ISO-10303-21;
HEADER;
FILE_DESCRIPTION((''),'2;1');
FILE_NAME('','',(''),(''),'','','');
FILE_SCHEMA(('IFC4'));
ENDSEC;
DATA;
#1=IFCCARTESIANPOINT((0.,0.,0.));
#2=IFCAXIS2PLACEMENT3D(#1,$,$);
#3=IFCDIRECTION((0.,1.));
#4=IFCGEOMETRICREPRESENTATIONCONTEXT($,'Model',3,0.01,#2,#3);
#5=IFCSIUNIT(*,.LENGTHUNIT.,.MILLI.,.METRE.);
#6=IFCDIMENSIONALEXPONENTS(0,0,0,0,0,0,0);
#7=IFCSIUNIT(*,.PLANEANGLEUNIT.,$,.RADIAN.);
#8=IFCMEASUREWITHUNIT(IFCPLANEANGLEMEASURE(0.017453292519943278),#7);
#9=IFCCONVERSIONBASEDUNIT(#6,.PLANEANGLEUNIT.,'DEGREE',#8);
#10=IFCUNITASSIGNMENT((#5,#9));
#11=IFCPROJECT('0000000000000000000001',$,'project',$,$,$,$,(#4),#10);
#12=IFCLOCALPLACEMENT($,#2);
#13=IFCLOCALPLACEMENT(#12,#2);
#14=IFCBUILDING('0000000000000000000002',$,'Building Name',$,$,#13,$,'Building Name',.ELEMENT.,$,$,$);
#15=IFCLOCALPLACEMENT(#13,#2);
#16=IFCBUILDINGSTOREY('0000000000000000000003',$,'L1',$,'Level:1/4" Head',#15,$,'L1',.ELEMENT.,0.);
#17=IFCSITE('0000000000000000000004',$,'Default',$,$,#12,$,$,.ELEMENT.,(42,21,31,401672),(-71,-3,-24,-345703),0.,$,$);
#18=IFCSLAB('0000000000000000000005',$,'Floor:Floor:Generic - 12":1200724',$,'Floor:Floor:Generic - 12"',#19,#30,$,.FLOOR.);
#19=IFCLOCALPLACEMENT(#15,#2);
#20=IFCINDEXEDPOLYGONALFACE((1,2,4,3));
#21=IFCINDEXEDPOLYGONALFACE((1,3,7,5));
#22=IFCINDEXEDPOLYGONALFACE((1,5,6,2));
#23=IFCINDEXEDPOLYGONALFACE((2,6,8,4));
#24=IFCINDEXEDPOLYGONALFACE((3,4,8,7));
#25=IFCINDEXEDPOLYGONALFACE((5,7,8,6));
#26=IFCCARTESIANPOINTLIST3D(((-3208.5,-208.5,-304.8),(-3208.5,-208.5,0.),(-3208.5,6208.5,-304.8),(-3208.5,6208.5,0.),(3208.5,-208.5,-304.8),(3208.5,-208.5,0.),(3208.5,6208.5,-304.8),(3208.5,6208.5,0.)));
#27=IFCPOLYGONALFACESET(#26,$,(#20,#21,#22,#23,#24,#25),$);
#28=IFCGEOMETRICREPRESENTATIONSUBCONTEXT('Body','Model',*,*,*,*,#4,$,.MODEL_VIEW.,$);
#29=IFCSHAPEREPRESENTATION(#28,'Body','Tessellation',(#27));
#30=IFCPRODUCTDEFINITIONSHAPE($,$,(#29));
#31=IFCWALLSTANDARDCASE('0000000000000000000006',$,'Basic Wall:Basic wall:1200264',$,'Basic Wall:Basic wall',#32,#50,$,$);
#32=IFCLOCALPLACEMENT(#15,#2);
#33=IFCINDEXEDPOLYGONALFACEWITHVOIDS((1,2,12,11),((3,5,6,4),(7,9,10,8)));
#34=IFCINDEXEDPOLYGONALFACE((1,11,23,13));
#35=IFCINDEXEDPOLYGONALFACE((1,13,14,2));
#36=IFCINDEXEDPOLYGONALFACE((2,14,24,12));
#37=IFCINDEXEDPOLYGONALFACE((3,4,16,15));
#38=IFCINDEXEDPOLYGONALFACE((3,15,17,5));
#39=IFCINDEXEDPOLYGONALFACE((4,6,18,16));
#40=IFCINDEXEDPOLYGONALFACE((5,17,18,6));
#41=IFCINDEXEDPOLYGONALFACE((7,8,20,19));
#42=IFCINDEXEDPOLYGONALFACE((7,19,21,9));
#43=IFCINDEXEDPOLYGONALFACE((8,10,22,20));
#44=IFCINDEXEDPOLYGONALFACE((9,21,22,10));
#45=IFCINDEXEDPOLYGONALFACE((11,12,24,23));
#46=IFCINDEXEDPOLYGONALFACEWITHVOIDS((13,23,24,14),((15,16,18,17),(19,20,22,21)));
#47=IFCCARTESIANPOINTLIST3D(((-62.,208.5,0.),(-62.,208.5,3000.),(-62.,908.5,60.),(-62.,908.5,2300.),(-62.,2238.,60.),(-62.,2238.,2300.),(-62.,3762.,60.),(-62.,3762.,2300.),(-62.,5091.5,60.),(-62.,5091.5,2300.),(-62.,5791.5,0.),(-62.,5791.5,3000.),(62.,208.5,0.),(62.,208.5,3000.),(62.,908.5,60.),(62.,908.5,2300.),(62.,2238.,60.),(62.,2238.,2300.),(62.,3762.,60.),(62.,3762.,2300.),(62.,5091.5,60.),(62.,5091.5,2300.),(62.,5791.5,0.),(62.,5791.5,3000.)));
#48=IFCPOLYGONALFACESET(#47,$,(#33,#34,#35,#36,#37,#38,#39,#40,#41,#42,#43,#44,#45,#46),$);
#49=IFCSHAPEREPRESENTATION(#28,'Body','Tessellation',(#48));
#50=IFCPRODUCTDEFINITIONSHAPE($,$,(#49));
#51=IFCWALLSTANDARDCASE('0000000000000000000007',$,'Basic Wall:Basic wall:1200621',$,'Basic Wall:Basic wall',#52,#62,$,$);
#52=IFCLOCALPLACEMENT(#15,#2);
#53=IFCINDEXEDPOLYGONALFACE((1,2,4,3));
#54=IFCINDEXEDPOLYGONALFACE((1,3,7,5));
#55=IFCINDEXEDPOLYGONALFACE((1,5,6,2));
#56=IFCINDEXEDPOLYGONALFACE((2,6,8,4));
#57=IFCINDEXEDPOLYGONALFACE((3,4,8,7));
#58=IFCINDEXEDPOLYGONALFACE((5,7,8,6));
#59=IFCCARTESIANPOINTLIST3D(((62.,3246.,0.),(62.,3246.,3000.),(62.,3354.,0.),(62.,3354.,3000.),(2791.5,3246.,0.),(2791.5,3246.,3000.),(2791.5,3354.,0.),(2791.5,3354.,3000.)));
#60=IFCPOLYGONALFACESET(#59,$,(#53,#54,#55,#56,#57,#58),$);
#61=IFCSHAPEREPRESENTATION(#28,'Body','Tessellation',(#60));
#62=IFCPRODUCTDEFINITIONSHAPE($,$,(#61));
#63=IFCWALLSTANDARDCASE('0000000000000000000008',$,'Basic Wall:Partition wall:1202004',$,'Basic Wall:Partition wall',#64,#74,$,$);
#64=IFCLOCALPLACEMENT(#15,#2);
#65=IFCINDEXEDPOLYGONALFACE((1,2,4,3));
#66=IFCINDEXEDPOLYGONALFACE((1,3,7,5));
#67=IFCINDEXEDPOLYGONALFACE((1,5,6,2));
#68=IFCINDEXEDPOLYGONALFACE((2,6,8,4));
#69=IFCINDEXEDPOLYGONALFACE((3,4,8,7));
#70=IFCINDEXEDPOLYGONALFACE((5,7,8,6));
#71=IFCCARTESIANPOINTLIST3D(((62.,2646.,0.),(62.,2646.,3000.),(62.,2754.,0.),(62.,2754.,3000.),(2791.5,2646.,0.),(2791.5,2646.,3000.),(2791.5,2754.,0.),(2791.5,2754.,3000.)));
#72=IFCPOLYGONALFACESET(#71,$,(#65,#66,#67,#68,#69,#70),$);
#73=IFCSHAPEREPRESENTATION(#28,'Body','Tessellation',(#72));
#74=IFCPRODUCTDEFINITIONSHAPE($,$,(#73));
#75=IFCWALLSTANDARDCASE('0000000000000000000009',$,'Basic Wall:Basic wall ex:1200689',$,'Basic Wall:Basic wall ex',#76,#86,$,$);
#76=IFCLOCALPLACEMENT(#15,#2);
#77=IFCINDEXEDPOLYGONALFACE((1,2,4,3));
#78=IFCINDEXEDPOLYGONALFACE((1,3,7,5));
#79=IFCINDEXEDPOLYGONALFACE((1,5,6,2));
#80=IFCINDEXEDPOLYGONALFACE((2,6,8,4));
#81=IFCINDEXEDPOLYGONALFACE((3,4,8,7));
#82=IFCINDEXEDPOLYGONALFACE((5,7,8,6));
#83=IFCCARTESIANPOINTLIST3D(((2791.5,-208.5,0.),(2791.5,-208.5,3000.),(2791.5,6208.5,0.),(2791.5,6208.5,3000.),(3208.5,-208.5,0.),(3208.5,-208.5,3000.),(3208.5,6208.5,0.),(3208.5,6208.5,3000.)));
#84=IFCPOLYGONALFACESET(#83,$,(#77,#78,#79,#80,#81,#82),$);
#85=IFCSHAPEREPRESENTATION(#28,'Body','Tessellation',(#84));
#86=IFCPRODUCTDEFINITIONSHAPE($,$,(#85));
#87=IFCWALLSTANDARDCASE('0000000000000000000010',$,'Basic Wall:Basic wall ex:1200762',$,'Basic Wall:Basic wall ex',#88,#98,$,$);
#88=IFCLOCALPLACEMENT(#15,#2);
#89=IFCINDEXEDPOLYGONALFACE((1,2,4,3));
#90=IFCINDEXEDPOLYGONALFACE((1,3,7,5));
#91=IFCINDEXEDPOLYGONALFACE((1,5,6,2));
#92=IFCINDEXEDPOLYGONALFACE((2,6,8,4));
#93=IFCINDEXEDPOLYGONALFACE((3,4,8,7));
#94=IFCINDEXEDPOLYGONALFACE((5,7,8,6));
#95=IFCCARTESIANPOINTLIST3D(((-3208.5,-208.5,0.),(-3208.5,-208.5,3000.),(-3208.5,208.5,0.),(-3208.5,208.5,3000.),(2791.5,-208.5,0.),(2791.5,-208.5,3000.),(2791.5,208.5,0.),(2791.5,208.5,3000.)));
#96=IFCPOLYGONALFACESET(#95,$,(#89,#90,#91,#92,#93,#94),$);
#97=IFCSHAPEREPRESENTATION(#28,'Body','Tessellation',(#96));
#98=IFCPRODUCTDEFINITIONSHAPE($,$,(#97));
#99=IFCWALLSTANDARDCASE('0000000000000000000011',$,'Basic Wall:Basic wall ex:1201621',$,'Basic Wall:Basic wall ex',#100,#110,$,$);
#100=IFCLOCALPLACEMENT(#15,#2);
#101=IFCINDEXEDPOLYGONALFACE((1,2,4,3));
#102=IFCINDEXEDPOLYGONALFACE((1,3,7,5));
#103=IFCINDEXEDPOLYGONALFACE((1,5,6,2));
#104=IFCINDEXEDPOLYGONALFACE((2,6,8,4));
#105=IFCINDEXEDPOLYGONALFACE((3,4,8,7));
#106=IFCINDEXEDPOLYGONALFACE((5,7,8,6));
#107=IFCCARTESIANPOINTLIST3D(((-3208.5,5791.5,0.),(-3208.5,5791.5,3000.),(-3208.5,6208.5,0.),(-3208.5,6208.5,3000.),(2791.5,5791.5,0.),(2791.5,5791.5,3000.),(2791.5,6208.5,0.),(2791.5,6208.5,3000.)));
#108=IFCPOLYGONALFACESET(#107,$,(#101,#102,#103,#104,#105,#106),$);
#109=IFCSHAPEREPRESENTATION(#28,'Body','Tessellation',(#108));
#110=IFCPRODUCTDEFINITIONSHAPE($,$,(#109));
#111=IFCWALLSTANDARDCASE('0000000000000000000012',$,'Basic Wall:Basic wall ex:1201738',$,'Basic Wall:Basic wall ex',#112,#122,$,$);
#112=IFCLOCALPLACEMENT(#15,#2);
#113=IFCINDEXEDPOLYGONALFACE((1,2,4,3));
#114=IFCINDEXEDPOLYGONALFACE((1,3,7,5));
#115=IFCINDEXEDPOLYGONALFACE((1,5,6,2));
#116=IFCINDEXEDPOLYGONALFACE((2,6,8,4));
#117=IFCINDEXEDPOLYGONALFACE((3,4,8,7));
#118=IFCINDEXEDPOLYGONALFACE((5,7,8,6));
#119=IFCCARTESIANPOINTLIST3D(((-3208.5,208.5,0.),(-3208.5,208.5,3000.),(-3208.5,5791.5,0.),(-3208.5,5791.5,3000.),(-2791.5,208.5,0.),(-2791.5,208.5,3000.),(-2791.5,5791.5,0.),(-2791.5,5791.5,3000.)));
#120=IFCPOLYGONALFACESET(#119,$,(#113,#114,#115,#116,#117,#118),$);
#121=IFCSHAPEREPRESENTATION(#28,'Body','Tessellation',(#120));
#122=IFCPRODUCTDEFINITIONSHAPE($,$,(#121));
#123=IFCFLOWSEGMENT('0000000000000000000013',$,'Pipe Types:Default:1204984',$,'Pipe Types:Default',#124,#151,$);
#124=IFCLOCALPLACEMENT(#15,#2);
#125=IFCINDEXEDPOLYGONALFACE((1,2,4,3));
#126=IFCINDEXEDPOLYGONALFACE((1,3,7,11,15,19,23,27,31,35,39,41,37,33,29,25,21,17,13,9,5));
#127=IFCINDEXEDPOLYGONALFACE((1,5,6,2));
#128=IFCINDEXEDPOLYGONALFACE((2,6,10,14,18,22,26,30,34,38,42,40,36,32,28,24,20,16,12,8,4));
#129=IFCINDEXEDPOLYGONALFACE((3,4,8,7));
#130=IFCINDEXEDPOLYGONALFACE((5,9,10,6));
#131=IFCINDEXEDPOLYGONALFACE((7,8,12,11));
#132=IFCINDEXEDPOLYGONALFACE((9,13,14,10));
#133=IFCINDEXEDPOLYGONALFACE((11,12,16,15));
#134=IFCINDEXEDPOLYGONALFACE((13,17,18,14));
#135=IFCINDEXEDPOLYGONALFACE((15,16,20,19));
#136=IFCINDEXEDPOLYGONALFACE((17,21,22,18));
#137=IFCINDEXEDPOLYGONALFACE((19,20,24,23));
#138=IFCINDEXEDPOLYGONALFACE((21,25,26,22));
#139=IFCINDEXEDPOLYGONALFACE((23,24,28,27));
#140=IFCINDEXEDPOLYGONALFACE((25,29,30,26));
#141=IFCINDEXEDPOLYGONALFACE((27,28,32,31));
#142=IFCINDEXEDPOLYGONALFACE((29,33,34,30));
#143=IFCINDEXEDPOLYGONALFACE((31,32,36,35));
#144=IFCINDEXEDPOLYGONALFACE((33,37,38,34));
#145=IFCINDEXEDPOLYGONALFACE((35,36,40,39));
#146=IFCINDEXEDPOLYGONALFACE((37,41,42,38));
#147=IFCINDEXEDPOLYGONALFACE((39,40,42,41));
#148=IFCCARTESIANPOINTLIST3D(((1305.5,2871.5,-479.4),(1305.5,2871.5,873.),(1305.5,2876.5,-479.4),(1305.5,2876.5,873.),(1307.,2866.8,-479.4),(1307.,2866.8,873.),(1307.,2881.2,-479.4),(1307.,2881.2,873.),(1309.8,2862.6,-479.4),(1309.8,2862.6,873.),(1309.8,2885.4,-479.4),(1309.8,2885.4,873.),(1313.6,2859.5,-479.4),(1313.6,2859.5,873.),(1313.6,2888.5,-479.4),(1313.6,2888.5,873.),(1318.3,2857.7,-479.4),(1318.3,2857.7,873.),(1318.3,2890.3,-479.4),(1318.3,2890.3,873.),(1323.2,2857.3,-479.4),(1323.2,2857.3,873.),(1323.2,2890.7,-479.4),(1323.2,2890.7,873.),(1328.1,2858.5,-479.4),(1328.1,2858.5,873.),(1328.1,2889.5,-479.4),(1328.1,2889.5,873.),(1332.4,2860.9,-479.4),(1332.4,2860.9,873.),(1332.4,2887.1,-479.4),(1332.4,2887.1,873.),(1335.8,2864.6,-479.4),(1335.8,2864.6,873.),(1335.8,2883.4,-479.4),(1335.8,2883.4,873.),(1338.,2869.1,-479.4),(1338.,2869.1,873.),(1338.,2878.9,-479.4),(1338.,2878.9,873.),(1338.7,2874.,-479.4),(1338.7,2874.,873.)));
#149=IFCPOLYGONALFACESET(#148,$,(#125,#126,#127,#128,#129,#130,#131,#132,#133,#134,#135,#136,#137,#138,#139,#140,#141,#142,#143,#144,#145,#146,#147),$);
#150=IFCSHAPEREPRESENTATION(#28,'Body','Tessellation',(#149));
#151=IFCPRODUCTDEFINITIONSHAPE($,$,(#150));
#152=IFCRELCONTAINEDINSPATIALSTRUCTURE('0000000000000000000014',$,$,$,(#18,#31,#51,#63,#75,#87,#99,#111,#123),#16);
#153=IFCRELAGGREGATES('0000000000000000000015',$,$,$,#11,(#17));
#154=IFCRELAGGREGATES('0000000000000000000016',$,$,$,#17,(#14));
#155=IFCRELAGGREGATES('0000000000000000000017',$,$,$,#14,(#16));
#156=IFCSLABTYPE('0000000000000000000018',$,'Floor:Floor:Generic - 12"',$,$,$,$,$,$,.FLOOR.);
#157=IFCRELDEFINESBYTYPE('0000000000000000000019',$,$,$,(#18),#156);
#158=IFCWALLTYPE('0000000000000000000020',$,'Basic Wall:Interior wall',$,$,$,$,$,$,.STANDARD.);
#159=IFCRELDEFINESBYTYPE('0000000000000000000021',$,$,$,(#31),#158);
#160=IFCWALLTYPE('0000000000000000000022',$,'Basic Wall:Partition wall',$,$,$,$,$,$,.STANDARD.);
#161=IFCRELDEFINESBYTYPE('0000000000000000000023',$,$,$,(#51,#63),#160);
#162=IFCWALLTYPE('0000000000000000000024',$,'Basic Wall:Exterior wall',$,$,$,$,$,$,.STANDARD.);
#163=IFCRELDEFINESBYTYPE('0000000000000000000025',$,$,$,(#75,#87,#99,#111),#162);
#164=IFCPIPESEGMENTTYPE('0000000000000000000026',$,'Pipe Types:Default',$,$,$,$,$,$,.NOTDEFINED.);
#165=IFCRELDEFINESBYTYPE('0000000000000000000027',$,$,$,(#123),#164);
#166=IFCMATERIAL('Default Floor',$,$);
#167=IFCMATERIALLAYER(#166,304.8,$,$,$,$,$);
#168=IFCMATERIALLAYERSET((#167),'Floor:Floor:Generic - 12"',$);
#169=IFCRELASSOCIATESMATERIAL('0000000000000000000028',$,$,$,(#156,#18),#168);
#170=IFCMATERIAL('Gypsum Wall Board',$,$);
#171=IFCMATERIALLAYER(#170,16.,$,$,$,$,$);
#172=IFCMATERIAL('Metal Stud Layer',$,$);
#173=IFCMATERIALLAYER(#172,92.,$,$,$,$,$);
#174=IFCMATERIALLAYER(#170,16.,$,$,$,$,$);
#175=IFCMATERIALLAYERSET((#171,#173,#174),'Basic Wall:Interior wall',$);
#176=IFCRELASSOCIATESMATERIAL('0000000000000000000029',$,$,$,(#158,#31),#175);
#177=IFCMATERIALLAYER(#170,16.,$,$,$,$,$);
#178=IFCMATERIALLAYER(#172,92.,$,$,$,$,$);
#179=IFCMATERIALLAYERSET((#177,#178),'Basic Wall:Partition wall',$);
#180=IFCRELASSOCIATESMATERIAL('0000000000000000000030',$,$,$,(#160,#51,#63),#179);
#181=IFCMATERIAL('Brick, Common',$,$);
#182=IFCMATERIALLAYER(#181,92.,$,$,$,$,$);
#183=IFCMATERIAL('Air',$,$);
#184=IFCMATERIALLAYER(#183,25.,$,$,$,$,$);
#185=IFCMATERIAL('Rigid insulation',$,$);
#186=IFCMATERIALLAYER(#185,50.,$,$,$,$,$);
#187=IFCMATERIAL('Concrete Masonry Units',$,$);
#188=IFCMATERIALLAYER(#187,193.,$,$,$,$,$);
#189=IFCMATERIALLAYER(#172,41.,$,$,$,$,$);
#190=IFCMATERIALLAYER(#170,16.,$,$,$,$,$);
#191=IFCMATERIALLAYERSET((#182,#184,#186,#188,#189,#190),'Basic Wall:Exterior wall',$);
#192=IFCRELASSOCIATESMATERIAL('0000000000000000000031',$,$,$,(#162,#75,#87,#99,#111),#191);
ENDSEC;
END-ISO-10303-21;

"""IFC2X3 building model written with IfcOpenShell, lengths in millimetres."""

from ifc_helpers import new_model, entity, si_unit, converted_unit, direction, frame, frame_2d, origin, origin_2d_with_axis, place, context, subcontext, project, spatial, rectangle, circle, extrude, material, layer, layer_set, layer_usage, type_object, element, save


model = new_model("IFC2X3")

# Units and contexts
model_context = context("Model", 3, precision=0.01, world=origin(), true_north=direction((0.0, 1.0)))
body_context = subcontext(model_context, "Body", "Model", "MODEL_VIEW")
ifc_project = project(units=[si_unit("LENGTHUNIT", "METRE", prefix="MILLI"), converted_unit("PLANEANGLEUNIT", "DEGREE", entity("IfcPlaneAngleMeasure", 0.017453292519943278), si_unit("PLANEANGLEUNIT", "RADIAN"), dimensions=[0, 0, 0, 0, 0, 0, 0])], contexts=[model_context])

# Site, building, storey
site_placement = place(None, origin())
site = spatial("IfcSite", under=ifc_project, at=site_placement, Name="Default", CompositionType="ELEMENT", RefLatitude=(42, 21, 31, 401672), RefLongitude=(-71, -3, -24, -345703), RefElevation=0.0)
building_placement = place(site_placement, origin())
building = spatial("IfcBuilding", under=site, at=building_placement, Name="Building Name", LongName="Building Name", CompositionType="ELEMENT")
storey_placement = place(building_placement, origin())
storey = spatial("IfcBuildingStorey", under=building, at=storey_placement, Name="L1", ObjectType="Level:1/4\" Head", LongName="L1", CompositionType="ELEMENT", Elevation=0.0)

# Slab
ifc_material_1 = material(Name="Default Floor")
ifc_layer_1 = layer(ifc_material_1, 304.8)
ifc_layer_set_1 = layer_set([ifc_layer_1], Name="Floor:Floor:Generic - 12\"")
ifc_layer_usage_1 = layer_usage(ifc_layer_set_1, "AXIS3", "POSITIVE", 0.0)
slab_type = type_object("IfcSlabType", Name="Floor:Floor:Generic - 12\"", PredefinedType="FLOOR", material=ifc_layer_set_1)
slab_placement = place(storey_placement, origin())
element("IfcSlab", 1, at=slab_placement, inside=storey, type_object=slab_type, material=ifc_layer_usage_1, Name="Floor:Floor:Generic - 12\":1200724", ObjectType="Floor:Floor:Generic - 12\"", PredefinedType="FLOOR", context=body_context, shape_type="SweptSolid", body=[
    extrude(rectangle(XDim=6417.0, YDim=6417.0, at=origin_2d_with_axis()), frame((0.0, 3000.0, 0.0), z_axis=(0.0, 0.0, -1.0), x_axis=(0.0, 1.0, 0.0)), (0.0, 0.0, 1.0), 304.8),
])

# Wall, openings
ifc_material_2 = material(Name="Gypsum Wall Board")
ifc_layer_2 = layer(ifc_material_2, 16.0)
ifc_material_3 = material(Name="Metal Stud Layer")
ifc_layer_3 = layer(ifc_material_3, 92.0)
ifc_layer_4 = layer(ifc_material_2, 16.0)
ifc_layer_set_2 = layer_set([ifc_layer_2, ifc_layer_3, ifc_layer_4], Name="Basic Wall:Interior wall")
ifc_layer_usage_2 = layer_usage(ifc_layer_set_2, "AXIS2", "NEGATIVE", 62.0)
wall_type_1 = type_object("IfcWallType", Name="Basic Wall:Interior wall", PredefinedType="STANDARD", material=ifc_layer_set_2)
wall_1_placement = place(storey_placement, frame((0.0, 5791.5, 0.0), z_axis=(0.0, 0.0, 1.0), x_axis=(0.0, -1.0, 0.0)))
wall_1 = element("IfcWallStandardCase", 2, at=wall_1_placement, inside=storey, type_object=wall_type_1, material=ifc_layer_usage_2, Name="Basic Wall:Basic wall:1200264", ObjectType="Basic Wall:Basic wall", context=body_context, shape_type="SweptSolid", body=[
    extrude(rectangle(XDim=5583.0, YDim=124.0, at=frame_2d((2791.5, 0.0), x_axis=(-1.0, 0.0))), origin(), (0.0, 0.0, 1.0), 3000.0),
])
opening_1_placement = place(wall_1_placement, origin())
element("IfcOpeningElement", 3, at=opening_1_placement, cuts=wall_1, ObjectType="Opening", context=body_context, shape_type="SweptSolid", body=[
    extrude(rectangle(XDim=2240.0, YDim=1329.5, at=origin_2d_with_axis()), frame((1364.8, -62.0, 1180.0), z_axis=(0.0, 1.0, 0.0), x_axis=(0.0, 0.0, -1.0)), (0.0, 0.0, 1.0), 124.0),
])
opening_2_placement = place(wall_1_placement, origin())
element("IfcOpeningElement", 4, at=opening_2_placement, cuts=wall_1, ObjectType="Opening", context=body_context, shape_type="SweptSolid", body=[
    extrude(rectangle(XDim=2240.0, YDim=1329.5, at=origin_2d_with_axis()), frame((4218.2, -62.0, 1180.0), z_axis=(0.0, 1.0, 0.0), x_axis=(0.0, 0.0, -1.0)), (0.0, 0.0, 1.0), 124.0),
])

# Walls
ifc_layer_5 = layer(ifc_material_2, 16.0)
ifc_layer_6 = layer(ifc_material_3, 92.0)
ifc_layer_set_3 = layer_set([ifc_layer_5, ifc_layer_6], Name="Basic Wall:Partition wall")
ifc_layer_usage_3 = layer_usage(ifc_layer_set_3, "AXIS2", "NEGATIVE", 54.0)
wall_type_2 = type_object("IfcWallType", Name="Basic Wall:Partition wall", PredefinedType="STANDARD", material=ifc_layer_set_3)
wall_2_placement = place(storey_placement, frame((62.0, 3300.0, 0.0)))
element("IfcWallStandardCase", 5, at=wall_2_placement, inside=storey, type_object=wall_type_2, material=ifc_layer_usage_3, Name="Basic Wall:Basic wall:1200621", ObjectType="Basic Wall:Basic wall", context=body_context, shape_type="SweptSolid", body=[
    extrude(rectangle(XDim=2729.5, YDim=108.0, at=frame_2d((1364.8, 0.0), x_axis=(-1.0, 0.0))), origin(), (0.0, 0.0, 1.0), 3000.0),
])
ifc_layer_usage_4 = layer_usage(ifc_layer_set_3, "AXIS2", "POSITIVE", -54.0)
wall_3_placement = place(storey_placement, frame((62.0, 2700.0, 0.0)))
element("IfcWallStandardCase", 6, at=wall_3_placement, inside=storey, type_object=wall_type_2, material=ifc_layer_usage_4, Name="Basic Wall:Partition wall:1202004", ObjectType="Basic Wall:Partition wall", context=body_context, shape_type="SweptSolid", body=[
    extrude(rectangle(XDim=2729.5, YDim=108.0, at=frame_2d((1364.8, 0.0), x_axis=(-1.0, 0.0))), origin(), (0.0, 0.0, 1.0), 3000.0),
])
ifc_material_4 = material(Name="Brick, Common")
ifc_layer_7 = layer(ifc_material_4, 92.0)
ifc_material_5 = material(Name="Air")
ifc_layer_8 = layer(ifc_material_5, 25.0)
ifc_material_6 = material(Name="Rigid insulation")
ifc_layer_9 = layer(ifc_material_6, 50.0)
ifc_material_7 = material(Name="Concrete Masonry Units")
ifc_layer_10 = layer(ifc_material_7, 193.0)
ifc_layer_11 = layer(ifc_material_3, 41.0)
ifc_layer_12 = layer(ifc_material_2, 16.0)
ifc_layer_set_4 = layer_set([ifc_layer_7, ifc_layer_8, ifc_layer_9, ifc_layer_10, ifc_layer_11, ifc_layer_12], Name="Basic Wall:Exterior wall")
ifc_layer_usage_5 = layer_usage(ifc_layer_set_4, "AXIS2", "NEGATIVE", 208.5)
wall_type_3 = type_object("IfcWallType", Name="Basic Wall:Exterior wall", PredefinedType="STANDARD", material=ifc_layer_set_4)
wall_4_placement = place(storey_placement, frame((3000.0, 6208.5, 0.0), z_axis=(0.0, 0.0, 1.0), x_axis=(0.0, -1.0, 0.0)))
element("IfcWallStandardCase", 7, at=wall_4_placement, inside=storey, type_object=wall_type_3, material=ifc_layer_usage_5, Name="Basic Wall:Basic wall ex:1200689", ObjectType="Basic Wall:Basic wall ex", context=body_context, shape_type="SweptSolid", body=[
    extrude(rectangle(XDim=6417.0, YDim=417.0, at=frame_2d((3208.5, 0.0), x_axis=(-1.0, 0.0))), origin(), (0.0, 0.0, 1.0), 3000.0),
])
ifc_layer_usage_6 = layer_usage(ifc_layer_set_4, "AXIS2", "NEGATIVE", 208.5)
wall_5_placement = place(storey_placement, frame((2791.5, 0.0, 0.0), z_axis=(0.0, 0.0, 1.0), x_axis=(-1.0, 0.0, 0.0)))
element("IfcWallStandardCase", 8, at=wall_5_placement, inside=storey, type_object=wall_type_3, material=ifc_layer_usage_6, Name="Basic Wall:Basic wall ex:1200762", ObjectType="Basic Wall:Basic wall ex", context=body_context, shape_type="SweptSolid", body=[
    extrude(rectangle(XDim=6000.0, YDim=417.0, at=frame_2d((3000.0, 0.0), x_axis=(-1.0, 0.0))), origin(), (0.0, 0.0, 1.0), 3000.0),
])
ifc_layer_usage_7 = layer_usage(ifc_layer_set_4, "AXIS2", "NEGATIVE", 208.5)
wall_6_placement = place(storey_placement, frame((-3208.5, 6000.0, 0.0)))
element("IfcWallStandardCase", 9, at=wall_6_placement, inside=storey, type_object=wall_type_3, material=ifc_layer_usage_7, Name="Basic Wall:Basic wall ex:1201621", ObjectType="Basic Wall:Basic wall ex", context=body_context, shape_type="SweptSolid", body=[
    extrude(rectangle(XDim=6000.0, YDim=417.0, at=frame_2d((3000.0, 0.0), x_axis=(-1.0, 0.0))), origin(), (0.0, 0.0, 1.0), 3000.0),
])
ifc_layer_usage_8 = layer_usage(ifc_layer_set_4, "AXIS2", "NEGATIVE", 208.5)
wall_7_placement = place(storey_placement, frame((-3000.0, 208.5, 0.0), z_axis=(0.0, 0.0, 1.0), x_axis=(0.0, 1.0, 0.0)))
element("IfcWallStandardCase", 10, at=wall_7_placement, inside=storey, type_object=wall_type_3, material=ifc_layer_usage_8, Name="Basic Wall:Basic wall ex:1201738", ObjectType="Basic Wall:Basic wall ex", context=body_context, shape_type="SweptSolid", body=[
    extrude(rectangle(XDim=5583.0, YDim=417.0, at=frame_2d((2791.5, 0.0), x_axis=(-1.0, 0.0))), origin(), (0.0, 0.0, 1.0), 3000.0),
])

# Flow segment
pipe_segment_type = type_object("IfcPipeSegmentType", Name="Pipe Types:Default", PredefinedType="NOTDEFINED")
flow_segment_1_placement = place(storey_placement, origin())
element("IfcFlowSegment", 11, at=flow_segment_1_placement, inside=storey, type_object=pipe_segment_type, Name="Pipe Types:Default:1204984", ObjectType="Pipe Types:Default", context=body_context, shape_type="SweptSolid", body=[
    extrude(circle(Radius=16.7, at=origin_2d_with_axis()), frame((1322.0, 2874.0, -479.4)), (0.0, 0.0, 1.0), 1352.4),
])

save(model, "model.ifc")
